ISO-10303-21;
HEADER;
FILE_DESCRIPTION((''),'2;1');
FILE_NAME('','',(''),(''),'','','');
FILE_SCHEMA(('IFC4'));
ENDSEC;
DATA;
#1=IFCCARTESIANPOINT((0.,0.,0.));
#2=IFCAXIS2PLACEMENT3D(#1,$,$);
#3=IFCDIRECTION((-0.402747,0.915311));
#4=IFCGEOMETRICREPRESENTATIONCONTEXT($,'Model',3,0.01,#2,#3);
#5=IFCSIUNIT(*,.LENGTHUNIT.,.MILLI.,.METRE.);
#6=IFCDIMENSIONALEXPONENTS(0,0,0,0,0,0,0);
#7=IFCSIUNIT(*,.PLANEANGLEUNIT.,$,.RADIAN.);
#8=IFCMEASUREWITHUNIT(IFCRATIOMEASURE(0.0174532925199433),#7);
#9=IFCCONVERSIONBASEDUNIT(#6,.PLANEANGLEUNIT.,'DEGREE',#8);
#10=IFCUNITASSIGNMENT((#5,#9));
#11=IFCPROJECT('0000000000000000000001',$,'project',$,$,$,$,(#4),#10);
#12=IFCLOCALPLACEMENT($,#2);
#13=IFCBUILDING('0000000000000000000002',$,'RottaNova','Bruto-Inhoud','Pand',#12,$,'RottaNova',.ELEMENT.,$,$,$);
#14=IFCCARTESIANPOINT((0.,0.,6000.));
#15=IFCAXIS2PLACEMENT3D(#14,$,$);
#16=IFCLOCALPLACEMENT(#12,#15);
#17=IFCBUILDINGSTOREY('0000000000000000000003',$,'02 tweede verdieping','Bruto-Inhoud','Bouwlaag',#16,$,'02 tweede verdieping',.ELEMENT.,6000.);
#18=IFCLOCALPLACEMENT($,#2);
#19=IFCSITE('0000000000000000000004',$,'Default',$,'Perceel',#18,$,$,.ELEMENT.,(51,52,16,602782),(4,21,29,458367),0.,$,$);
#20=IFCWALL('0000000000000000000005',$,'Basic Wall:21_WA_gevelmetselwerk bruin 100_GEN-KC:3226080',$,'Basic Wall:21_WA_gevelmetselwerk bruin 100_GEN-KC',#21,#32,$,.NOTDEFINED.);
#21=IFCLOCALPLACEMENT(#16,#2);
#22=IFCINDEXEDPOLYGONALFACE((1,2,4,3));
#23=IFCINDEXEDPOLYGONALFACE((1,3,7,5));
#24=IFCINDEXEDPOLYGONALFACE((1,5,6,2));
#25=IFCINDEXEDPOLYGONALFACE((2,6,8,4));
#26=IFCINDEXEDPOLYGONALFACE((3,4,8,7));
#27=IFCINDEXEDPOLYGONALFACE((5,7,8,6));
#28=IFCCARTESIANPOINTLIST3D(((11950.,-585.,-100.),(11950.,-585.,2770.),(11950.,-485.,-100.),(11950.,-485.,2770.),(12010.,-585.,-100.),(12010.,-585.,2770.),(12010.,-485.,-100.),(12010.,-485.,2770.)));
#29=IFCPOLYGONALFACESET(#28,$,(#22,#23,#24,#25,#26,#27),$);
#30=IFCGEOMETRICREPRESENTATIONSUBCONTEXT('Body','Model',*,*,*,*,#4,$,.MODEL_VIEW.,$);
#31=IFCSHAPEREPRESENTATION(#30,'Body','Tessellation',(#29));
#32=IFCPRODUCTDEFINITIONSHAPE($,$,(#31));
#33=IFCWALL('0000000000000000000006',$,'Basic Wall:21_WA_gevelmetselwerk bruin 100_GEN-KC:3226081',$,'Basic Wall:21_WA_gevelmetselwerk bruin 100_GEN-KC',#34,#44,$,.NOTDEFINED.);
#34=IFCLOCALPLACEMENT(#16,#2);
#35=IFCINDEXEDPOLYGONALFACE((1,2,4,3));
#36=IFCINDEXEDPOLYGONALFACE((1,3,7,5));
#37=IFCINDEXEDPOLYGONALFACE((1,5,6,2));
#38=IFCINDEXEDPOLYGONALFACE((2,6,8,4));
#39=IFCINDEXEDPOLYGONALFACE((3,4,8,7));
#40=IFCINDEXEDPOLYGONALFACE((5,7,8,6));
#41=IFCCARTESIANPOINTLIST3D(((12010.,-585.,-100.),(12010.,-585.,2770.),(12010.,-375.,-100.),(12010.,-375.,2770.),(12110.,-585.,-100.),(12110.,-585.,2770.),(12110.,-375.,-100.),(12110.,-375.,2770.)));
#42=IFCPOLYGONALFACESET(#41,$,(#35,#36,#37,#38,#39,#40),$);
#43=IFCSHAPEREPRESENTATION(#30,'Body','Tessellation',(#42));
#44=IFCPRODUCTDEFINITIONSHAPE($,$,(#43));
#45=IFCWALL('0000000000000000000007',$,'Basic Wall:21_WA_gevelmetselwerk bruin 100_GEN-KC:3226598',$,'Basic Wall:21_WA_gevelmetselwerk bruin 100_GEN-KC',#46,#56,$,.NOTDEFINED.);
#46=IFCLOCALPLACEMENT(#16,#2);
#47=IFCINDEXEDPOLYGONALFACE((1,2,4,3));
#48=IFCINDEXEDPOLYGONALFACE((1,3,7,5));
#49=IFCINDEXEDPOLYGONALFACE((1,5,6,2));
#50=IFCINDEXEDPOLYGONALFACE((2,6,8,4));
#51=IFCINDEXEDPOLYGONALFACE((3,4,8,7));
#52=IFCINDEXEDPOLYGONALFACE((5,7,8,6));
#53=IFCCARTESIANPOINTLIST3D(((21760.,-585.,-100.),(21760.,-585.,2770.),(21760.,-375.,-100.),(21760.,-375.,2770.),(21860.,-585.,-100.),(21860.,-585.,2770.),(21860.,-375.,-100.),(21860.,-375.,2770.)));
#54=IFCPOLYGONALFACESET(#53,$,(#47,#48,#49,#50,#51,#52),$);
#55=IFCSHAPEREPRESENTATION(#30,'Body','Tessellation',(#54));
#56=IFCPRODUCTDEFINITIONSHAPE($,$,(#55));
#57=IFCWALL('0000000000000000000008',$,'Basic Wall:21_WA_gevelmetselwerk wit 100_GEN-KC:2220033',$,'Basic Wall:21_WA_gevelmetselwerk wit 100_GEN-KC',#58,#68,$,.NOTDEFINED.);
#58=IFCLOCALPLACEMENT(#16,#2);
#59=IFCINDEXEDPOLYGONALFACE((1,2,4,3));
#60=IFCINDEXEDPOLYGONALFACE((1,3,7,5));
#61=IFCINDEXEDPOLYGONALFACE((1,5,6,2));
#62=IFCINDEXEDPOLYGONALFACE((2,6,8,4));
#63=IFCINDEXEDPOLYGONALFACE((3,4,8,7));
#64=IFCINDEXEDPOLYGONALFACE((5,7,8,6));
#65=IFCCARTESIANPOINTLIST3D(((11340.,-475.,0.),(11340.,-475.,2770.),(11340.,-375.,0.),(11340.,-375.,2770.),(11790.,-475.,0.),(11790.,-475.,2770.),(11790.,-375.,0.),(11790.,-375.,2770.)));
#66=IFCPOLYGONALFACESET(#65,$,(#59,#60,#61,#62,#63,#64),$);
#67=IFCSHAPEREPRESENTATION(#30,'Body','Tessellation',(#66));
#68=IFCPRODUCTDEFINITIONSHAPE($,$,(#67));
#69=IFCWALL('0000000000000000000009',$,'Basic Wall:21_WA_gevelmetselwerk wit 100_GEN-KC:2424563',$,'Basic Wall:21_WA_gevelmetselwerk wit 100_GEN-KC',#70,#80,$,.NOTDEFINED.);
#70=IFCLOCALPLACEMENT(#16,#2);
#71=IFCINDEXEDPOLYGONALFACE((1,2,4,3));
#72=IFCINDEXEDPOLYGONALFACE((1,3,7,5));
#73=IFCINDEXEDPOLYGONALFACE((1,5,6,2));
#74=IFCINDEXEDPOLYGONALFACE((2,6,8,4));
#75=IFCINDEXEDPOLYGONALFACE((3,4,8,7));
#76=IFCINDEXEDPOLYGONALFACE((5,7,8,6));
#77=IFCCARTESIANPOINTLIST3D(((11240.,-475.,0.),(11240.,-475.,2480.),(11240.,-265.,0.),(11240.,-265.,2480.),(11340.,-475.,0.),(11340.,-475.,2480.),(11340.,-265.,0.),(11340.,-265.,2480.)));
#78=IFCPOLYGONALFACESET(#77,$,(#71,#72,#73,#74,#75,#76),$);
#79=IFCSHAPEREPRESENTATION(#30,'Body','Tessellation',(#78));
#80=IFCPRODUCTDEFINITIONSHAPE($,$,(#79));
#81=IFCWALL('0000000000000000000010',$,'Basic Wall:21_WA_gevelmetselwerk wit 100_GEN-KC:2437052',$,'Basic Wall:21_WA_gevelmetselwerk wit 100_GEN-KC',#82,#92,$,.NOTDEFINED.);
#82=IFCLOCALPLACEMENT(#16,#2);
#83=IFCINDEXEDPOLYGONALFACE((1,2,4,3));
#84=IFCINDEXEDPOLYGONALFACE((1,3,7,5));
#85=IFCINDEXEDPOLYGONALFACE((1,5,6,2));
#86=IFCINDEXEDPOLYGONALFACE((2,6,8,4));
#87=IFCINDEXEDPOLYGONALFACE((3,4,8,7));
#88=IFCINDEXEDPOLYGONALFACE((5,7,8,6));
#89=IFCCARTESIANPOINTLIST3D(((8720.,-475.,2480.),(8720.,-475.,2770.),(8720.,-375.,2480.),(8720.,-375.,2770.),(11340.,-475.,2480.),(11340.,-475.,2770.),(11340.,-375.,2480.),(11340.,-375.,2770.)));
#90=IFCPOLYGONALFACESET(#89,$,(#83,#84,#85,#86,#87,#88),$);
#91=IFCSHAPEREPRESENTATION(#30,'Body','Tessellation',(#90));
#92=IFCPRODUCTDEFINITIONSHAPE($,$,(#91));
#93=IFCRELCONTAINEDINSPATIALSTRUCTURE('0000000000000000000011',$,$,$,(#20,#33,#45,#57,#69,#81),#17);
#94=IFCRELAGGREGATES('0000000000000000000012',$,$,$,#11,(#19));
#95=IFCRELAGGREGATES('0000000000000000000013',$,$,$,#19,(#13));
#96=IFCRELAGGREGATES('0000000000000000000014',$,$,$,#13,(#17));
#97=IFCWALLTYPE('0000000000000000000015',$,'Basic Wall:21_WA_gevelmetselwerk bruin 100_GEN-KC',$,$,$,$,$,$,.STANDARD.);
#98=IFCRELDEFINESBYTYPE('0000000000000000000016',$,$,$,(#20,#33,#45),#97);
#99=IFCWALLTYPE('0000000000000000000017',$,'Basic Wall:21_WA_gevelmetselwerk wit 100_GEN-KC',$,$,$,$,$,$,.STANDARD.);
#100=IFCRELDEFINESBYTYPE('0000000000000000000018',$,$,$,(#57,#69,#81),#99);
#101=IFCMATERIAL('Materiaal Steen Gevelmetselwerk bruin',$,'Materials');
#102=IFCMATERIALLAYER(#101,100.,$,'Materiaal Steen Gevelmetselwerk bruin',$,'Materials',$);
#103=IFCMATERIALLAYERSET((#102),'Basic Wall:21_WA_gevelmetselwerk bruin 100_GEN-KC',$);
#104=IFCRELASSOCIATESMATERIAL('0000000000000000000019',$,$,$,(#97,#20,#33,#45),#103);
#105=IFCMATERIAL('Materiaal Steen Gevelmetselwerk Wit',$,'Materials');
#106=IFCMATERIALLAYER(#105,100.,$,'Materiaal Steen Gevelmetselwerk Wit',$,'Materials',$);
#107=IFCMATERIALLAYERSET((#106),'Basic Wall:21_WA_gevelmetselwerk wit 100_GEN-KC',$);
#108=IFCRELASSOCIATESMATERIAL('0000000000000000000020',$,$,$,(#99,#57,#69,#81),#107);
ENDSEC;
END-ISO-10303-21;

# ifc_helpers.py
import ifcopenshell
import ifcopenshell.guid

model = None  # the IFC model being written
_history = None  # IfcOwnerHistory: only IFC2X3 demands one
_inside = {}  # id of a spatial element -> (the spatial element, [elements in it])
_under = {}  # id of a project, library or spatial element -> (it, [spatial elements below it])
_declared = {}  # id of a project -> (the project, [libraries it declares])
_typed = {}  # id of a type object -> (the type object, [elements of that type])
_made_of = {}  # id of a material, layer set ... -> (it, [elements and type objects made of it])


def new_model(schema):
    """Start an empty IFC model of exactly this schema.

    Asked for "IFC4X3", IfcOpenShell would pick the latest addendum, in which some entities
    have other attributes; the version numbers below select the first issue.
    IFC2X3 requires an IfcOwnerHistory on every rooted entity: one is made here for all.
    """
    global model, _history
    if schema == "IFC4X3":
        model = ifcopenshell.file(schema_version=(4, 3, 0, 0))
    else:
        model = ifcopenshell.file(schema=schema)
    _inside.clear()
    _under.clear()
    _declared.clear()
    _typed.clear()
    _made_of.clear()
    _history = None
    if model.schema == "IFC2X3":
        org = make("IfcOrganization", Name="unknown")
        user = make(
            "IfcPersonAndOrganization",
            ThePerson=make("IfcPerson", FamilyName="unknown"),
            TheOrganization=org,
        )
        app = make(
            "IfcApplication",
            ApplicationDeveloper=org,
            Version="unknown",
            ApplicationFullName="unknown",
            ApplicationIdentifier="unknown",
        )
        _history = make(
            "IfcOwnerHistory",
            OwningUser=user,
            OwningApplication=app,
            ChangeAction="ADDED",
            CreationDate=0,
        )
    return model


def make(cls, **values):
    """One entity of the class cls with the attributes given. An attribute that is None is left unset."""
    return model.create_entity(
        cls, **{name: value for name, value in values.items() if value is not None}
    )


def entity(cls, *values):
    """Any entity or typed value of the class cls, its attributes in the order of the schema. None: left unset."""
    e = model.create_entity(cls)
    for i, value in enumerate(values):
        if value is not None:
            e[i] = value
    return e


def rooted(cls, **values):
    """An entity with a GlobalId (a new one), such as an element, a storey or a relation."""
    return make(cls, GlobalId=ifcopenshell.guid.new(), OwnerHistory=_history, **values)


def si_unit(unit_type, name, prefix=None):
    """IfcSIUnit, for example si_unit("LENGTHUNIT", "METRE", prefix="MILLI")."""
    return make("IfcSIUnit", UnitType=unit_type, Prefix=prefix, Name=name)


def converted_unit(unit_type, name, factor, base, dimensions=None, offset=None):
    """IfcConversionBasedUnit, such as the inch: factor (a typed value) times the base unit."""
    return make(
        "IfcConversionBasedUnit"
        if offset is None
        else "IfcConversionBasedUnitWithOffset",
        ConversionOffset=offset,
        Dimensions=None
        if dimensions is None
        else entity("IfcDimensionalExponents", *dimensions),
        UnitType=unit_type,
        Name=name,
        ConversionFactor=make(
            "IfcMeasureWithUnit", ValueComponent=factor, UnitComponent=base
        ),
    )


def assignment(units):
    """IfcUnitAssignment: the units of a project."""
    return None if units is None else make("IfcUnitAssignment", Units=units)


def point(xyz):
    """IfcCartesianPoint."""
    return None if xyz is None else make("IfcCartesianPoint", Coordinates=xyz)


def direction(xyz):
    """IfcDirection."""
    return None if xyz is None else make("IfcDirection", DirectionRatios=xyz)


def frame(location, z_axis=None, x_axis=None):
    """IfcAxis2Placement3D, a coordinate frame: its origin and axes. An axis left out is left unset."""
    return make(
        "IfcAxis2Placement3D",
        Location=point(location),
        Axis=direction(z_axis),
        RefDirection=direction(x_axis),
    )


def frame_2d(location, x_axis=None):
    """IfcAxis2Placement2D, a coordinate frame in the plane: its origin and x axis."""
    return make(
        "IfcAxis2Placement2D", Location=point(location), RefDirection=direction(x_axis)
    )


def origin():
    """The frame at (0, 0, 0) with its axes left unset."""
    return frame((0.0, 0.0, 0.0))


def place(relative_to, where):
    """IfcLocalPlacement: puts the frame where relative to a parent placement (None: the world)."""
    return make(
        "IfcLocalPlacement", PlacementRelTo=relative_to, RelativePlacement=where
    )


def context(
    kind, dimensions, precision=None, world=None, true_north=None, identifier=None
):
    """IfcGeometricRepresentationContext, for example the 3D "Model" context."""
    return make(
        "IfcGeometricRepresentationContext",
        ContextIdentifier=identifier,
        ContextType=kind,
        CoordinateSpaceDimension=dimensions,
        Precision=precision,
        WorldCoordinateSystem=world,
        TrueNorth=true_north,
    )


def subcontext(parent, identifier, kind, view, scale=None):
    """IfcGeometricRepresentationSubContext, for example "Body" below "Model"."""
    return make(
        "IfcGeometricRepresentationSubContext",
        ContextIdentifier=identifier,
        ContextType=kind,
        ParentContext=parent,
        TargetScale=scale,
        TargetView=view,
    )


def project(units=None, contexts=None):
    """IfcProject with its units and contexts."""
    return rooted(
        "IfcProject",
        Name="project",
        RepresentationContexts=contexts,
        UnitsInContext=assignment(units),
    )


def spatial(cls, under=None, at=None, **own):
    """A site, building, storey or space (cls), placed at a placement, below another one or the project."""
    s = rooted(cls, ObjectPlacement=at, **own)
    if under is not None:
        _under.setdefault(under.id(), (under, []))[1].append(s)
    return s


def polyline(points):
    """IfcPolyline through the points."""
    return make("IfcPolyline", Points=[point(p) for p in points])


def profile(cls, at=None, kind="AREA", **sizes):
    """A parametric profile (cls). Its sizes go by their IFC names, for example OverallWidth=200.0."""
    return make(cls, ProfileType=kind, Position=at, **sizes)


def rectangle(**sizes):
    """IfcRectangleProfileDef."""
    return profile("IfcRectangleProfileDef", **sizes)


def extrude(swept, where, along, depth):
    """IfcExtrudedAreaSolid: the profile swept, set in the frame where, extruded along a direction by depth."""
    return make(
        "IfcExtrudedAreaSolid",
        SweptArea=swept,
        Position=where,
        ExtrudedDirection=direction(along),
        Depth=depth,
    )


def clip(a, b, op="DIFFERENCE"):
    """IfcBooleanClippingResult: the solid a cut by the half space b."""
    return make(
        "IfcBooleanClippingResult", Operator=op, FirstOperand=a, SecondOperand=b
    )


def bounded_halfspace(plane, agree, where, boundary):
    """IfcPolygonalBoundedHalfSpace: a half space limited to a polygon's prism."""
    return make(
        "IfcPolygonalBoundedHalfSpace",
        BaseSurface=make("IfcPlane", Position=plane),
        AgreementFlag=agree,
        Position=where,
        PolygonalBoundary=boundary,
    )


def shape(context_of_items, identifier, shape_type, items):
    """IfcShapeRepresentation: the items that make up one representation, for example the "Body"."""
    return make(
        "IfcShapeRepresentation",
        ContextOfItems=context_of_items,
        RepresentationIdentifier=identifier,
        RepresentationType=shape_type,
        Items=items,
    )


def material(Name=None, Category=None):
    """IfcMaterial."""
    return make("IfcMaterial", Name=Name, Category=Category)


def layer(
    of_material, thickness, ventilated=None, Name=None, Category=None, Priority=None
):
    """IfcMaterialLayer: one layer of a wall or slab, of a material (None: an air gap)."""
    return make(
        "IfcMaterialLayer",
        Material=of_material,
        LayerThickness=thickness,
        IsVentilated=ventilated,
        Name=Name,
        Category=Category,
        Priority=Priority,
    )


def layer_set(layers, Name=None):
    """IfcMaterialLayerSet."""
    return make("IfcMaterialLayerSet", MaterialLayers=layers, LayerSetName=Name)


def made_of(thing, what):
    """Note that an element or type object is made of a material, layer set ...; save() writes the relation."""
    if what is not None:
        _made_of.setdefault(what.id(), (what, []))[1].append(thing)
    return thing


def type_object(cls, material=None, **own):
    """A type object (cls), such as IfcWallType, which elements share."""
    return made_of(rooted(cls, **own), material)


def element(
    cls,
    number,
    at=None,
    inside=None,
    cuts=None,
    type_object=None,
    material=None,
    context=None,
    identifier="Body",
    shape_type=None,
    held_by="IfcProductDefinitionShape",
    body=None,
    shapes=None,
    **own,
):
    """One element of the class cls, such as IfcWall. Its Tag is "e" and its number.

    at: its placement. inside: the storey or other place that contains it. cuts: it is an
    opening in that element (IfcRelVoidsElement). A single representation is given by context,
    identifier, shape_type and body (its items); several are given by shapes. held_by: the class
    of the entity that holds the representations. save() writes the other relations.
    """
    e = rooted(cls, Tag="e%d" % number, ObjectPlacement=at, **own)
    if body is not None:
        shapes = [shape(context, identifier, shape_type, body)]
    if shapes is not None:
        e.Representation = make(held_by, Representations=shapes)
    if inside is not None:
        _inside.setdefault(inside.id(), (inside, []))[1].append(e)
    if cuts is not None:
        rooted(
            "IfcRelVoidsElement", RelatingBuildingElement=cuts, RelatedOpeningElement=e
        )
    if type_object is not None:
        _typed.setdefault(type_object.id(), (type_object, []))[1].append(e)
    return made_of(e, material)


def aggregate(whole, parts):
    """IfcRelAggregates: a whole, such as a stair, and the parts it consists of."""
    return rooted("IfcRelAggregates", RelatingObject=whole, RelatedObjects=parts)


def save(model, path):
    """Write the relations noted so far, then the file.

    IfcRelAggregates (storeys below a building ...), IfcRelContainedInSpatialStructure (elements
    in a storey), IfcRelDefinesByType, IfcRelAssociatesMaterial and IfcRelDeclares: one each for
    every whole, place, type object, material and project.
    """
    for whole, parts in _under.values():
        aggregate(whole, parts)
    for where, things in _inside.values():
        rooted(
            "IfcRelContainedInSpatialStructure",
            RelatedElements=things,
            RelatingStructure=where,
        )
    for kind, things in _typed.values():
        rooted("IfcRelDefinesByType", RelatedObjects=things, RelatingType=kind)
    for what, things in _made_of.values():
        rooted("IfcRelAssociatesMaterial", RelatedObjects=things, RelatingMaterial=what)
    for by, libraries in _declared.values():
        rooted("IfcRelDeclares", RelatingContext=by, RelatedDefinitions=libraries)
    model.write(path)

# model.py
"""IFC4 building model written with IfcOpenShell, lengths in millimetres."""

from ifc_helpers import new_model, entity, si_unit, converted_unit, direction, frame, frame_2d, origin, place, context, subcontext, project, spatial, polyline, rectangle, extrude, clip, bounded_halfspace, material, layer, layer_set, type_object, element, save


model = new_model("IFC4")

# Units and contexts
model_context = context("Model", 3, precision=0.01, world=origin(), true_north=direction((-0.402747, 0.915311)))
body_context = subcontext(model_context, "Body", "Model", "MODEL_VIEW")
ifc_project = project(units=[si_unit("LENGTHUNIT", "METRE", prefix="MILLI"), converted_unit("PLANEANGLEUNIT", "DEGREE", entity("IfcRatioMeasure", 0.0174532925199433), si_unit("PLANEANGLEUNIT", "RADIAN"), dimensions=[0, 0, 0, 0, 0, 0, 0])], contexts=[model_context])

# Site, building, storey
site_placement = place(None, origin())
site = spatial("IfcSite", under=ifc_project, at=site_placement, Name="Default", ObjectType="Perceel", CompositionType="ELEMENT", RefLatitude=(51, 52, 16, 602782), RefLongitude=(4, 21, 29, 458367), RefElevation=0.0)
building_placement = place(None, origin())
building = spatial("IfcBuilding", under=site, at=building_placement, Name="RottaNova", Description="Bruto-Inhoud", ObjectType="Pand", LongName="RottaNova", CompositionType="ELEMENT")
storey_placement = place(building_placement, frame((0.0, 0.0, 6000.0)))
storey = spatial("IfcBuildingStorey", under=building, at=storey_placement, Name="02 tweede verdieping", Description="Bruto-Inhoud", ObjectType="Bouwlaag", LongName="02 tweede verdieping", CompositionType="ELEMENT", Elevation=6000.0)

# Walls
ifc_material_1 = material(Name="Materiaal Steen Gevelmetselwerk bruin", Category="Materials")
ifc_layer_1 = layer(ifc_material_1, 100.0, Name="Materiaal Steen Gevelmetselwerk bruin", Category="Materials")
ifc_layer_set_1 = layer_set([ifc_layer_1], Name="Basic Wall:21_WA_gevelmetselwerk bruin 100_GEN-KC")
wall_type_1 = type_object("IfcWallType", Name="Basic Wall:21_WA_gevelmetselwerk bruin 100_GEN-KC", PredefinedType="STANDARD", material=ifc_layer_set_1)
wall_1_placement = place(storey_placement, frame((12010.0, -535.0, -100.0), z_axis=(0.0, 0.0, 1.0), x_axis=(-1.0, 0.0, 0.0)))
element("IfcWall", 1, at=wall_1_placement, inside=storey, type_object=wall_type_1, material=ifc_layer_set_1, Name="Basic Wall:21_WA_gevelmetselwerk bruin 100_GEN-KC:3226080", ObjectType="Basic Wall:21_WA_gevelmetselwerk bruin 100_GEN-KC", PredefinedType="NOTDEFINED", context=body_context, shape_type="SweptSolid", body=[
    extrude(rectangle(XDim=60.0, YDim=100.0, at=frame_2d((30.0, 0.0), x_axis=(-1.0, 0.0))), origin(), (0.0, 0.0, 1.0), 2870.0),
])
wall_2_placement = place(storey_placement, frame((12060.0, -585.0, -100.0), z_axis=(0.0, 0.0, 1.0), x_axis=(0.0, 1.0, 0.0)))
element("IfcWall", 2, at=wall_2_placement, inside=storey, type_object=wall_type_1, material=ifc_layer_set_1, Name="Basic Wall:21_WA_gevelmetselwerk bruin 100_GEN-KC:3226081", ObjectType="Basic Wall:21_WA_gevelmetselwerk bruin 100_GEN-KC", PredefinedType="NOTDEFINED", context=body_context, shape_type="SweptSolid", body=[
    extrude(rectangle(XDim=210.0, YDim=100.0, at=frame_2d((105.0, 0.0), x_axis=(-1.0, 0.0))), origin(), (0.0, 0.0, 1.0), 2870.0),
])
wall_3_placement = place(storey_placement, frame((21810.0, -585.0, -100.0), z_axis=(0.0, 0.0, 1.0), x_axis=(0.0, 1.0, 0.0)))
element("IfcWall", 3, at=wall_3_placement, inside=storey, type_object=wall_type_1, material=ifc_layer_set_1, Name="Basic Wall:21_WA_gevelmetselwerk bruin 100_GEN-KC:3226598", ObjectType="Basic Wall:21_WA_gevelmetselwerk bruin 100_GEN-KC", PredefinedType="NOTDEFINED", context=body_context, shape_type="SweptSolid", body=[
    extrude(rectangle(XDim=210.0, YDim=100.0, at=frame_2d((105.0, 0.0), x_axis=(-1.0, 0.0))), origin(), (0.0, 0.0, 1.0), 2870.0),
])
ifc_material_2 = material(Name="Materiaal Steen Gevelmetselwerk Wit", Category="Materials")
ifc_layer_2 = layer(ifc_material_2, 100.0, Name="Materiaal Steen Gevelmetselwerk Wit", Category="Materials")
ifc_layer_set_2 = layer_set([ifc_layer_2], Name="Basic Wall:21_WA_gevelmetselwerk wit 100_GEN-KC")
wall_type_2 = type_object("IfcWallType", Name="Basic Wall:21_WA_gevelmetselwerk wit 100_GEN-KC", PredefinedType="STANDARD", material=ifc_layer_set_2)
wall_4_placement = place(storey_placement, frame((11790.0, -425.0, 0.0), z_axis=(0.0, 0.0, 1.0), x_axis=(-1.0, 0.0, 0.0)))
element("IfcWall", 4, at=wall_4_placement, inside=storey, type_object=wall_type_2, material=ifc_layer_set_2, Name="Basic Wall:21_WA_gevelmetselwerk wit 100_GEN-KC:2220033", ObjectType="Basic Wall:21_WA_gevelmetselwerk wit 100_GEN-KC", PredefinedType="NOTDEFINED", context=body_context, shape_type="SweptSolid", body=[
    extrude(rectangle(XDim=450.0, YDim=100.0, at=frame_2d((225.0, 0.0), x_axis=(-1.0, 0.0))), origin(), (0.0, 0.0, 1.0), 2770.0),
])
wall_5_placement = place(storey_placement, frame((11290.0, -265.0, 0.0), z_axis=(0.0, 0.0, 1.0), x_axis=(0.0, -1.0, 0.0)))
element("IfcWall", 5, at=wall_5_placement, inside=storey, type_object=wall_type_2, material=ifc_layer_set_2, Name="Basic Wall:21_WA_gevelmetselwerk wit 100_GEN-KC:2424563", ObjectType="Basic Wall:21_WA_gevelmetselwerk wit 100_GEN-KC", PredefinedType="NOTDEFINED", context=body_context, shape_type="SweptSolid", body=[
    extrude(rectangle(XDim=210.0, YDim=100.0, at=frame_2d((105.0, 0.0), x_axis=(-1.0, 0.0))), origin(), (0.0, 0.0, 1.0), 2480.0),
])
wall_6_placement = place(storey_placement, frame((11340.0, -425.0, 2480.0), z_axis=(0.0, 0.0, 1.0), x_axis=(-1.0, 0.0, 0.0)))
element("IfcWall", 6, at=wall_6_placement, inside=storey, type_object=wall_type_2, material=ifc_layer_set_2, Name="Basic Wall:21_WA_gevelmetselwerk wit 100_GEN-KC:2437052", ObjectType="Basic Wall:21_WA_gevelmetselwerk wit 100_GEN-KC", PredefinedType="NOTDEFINED", context=body_context, shape_type="Clipping", body=[
    clip(extrude(rectangle(XDim=2620.0, YDim=100.0, at=frame_2d((1310.0, 0.0), x_axis=(-1.0, 0.0))), origin(), (0.0, 0.0, 1.0), 290.0), bounded_halfspace(frame((2620.0, -50.0, 290.0), z_axis=(1.0, 0.0, 0.0), x_axis=(0.0, 1.0, 0.0)), False, frame((2620.0, -50.0, 290.0), z_axis=(1.0, 0.0, 0.0), x_axis=(0.0, 1.0, 0.0)), polyline([(0.0, 0.0), (0.0, -88392.0), (30480.0, -88392.0), (30480.0, 0.0), (0.0, 0.0)]))),
])

save(model, "model.ifc")
